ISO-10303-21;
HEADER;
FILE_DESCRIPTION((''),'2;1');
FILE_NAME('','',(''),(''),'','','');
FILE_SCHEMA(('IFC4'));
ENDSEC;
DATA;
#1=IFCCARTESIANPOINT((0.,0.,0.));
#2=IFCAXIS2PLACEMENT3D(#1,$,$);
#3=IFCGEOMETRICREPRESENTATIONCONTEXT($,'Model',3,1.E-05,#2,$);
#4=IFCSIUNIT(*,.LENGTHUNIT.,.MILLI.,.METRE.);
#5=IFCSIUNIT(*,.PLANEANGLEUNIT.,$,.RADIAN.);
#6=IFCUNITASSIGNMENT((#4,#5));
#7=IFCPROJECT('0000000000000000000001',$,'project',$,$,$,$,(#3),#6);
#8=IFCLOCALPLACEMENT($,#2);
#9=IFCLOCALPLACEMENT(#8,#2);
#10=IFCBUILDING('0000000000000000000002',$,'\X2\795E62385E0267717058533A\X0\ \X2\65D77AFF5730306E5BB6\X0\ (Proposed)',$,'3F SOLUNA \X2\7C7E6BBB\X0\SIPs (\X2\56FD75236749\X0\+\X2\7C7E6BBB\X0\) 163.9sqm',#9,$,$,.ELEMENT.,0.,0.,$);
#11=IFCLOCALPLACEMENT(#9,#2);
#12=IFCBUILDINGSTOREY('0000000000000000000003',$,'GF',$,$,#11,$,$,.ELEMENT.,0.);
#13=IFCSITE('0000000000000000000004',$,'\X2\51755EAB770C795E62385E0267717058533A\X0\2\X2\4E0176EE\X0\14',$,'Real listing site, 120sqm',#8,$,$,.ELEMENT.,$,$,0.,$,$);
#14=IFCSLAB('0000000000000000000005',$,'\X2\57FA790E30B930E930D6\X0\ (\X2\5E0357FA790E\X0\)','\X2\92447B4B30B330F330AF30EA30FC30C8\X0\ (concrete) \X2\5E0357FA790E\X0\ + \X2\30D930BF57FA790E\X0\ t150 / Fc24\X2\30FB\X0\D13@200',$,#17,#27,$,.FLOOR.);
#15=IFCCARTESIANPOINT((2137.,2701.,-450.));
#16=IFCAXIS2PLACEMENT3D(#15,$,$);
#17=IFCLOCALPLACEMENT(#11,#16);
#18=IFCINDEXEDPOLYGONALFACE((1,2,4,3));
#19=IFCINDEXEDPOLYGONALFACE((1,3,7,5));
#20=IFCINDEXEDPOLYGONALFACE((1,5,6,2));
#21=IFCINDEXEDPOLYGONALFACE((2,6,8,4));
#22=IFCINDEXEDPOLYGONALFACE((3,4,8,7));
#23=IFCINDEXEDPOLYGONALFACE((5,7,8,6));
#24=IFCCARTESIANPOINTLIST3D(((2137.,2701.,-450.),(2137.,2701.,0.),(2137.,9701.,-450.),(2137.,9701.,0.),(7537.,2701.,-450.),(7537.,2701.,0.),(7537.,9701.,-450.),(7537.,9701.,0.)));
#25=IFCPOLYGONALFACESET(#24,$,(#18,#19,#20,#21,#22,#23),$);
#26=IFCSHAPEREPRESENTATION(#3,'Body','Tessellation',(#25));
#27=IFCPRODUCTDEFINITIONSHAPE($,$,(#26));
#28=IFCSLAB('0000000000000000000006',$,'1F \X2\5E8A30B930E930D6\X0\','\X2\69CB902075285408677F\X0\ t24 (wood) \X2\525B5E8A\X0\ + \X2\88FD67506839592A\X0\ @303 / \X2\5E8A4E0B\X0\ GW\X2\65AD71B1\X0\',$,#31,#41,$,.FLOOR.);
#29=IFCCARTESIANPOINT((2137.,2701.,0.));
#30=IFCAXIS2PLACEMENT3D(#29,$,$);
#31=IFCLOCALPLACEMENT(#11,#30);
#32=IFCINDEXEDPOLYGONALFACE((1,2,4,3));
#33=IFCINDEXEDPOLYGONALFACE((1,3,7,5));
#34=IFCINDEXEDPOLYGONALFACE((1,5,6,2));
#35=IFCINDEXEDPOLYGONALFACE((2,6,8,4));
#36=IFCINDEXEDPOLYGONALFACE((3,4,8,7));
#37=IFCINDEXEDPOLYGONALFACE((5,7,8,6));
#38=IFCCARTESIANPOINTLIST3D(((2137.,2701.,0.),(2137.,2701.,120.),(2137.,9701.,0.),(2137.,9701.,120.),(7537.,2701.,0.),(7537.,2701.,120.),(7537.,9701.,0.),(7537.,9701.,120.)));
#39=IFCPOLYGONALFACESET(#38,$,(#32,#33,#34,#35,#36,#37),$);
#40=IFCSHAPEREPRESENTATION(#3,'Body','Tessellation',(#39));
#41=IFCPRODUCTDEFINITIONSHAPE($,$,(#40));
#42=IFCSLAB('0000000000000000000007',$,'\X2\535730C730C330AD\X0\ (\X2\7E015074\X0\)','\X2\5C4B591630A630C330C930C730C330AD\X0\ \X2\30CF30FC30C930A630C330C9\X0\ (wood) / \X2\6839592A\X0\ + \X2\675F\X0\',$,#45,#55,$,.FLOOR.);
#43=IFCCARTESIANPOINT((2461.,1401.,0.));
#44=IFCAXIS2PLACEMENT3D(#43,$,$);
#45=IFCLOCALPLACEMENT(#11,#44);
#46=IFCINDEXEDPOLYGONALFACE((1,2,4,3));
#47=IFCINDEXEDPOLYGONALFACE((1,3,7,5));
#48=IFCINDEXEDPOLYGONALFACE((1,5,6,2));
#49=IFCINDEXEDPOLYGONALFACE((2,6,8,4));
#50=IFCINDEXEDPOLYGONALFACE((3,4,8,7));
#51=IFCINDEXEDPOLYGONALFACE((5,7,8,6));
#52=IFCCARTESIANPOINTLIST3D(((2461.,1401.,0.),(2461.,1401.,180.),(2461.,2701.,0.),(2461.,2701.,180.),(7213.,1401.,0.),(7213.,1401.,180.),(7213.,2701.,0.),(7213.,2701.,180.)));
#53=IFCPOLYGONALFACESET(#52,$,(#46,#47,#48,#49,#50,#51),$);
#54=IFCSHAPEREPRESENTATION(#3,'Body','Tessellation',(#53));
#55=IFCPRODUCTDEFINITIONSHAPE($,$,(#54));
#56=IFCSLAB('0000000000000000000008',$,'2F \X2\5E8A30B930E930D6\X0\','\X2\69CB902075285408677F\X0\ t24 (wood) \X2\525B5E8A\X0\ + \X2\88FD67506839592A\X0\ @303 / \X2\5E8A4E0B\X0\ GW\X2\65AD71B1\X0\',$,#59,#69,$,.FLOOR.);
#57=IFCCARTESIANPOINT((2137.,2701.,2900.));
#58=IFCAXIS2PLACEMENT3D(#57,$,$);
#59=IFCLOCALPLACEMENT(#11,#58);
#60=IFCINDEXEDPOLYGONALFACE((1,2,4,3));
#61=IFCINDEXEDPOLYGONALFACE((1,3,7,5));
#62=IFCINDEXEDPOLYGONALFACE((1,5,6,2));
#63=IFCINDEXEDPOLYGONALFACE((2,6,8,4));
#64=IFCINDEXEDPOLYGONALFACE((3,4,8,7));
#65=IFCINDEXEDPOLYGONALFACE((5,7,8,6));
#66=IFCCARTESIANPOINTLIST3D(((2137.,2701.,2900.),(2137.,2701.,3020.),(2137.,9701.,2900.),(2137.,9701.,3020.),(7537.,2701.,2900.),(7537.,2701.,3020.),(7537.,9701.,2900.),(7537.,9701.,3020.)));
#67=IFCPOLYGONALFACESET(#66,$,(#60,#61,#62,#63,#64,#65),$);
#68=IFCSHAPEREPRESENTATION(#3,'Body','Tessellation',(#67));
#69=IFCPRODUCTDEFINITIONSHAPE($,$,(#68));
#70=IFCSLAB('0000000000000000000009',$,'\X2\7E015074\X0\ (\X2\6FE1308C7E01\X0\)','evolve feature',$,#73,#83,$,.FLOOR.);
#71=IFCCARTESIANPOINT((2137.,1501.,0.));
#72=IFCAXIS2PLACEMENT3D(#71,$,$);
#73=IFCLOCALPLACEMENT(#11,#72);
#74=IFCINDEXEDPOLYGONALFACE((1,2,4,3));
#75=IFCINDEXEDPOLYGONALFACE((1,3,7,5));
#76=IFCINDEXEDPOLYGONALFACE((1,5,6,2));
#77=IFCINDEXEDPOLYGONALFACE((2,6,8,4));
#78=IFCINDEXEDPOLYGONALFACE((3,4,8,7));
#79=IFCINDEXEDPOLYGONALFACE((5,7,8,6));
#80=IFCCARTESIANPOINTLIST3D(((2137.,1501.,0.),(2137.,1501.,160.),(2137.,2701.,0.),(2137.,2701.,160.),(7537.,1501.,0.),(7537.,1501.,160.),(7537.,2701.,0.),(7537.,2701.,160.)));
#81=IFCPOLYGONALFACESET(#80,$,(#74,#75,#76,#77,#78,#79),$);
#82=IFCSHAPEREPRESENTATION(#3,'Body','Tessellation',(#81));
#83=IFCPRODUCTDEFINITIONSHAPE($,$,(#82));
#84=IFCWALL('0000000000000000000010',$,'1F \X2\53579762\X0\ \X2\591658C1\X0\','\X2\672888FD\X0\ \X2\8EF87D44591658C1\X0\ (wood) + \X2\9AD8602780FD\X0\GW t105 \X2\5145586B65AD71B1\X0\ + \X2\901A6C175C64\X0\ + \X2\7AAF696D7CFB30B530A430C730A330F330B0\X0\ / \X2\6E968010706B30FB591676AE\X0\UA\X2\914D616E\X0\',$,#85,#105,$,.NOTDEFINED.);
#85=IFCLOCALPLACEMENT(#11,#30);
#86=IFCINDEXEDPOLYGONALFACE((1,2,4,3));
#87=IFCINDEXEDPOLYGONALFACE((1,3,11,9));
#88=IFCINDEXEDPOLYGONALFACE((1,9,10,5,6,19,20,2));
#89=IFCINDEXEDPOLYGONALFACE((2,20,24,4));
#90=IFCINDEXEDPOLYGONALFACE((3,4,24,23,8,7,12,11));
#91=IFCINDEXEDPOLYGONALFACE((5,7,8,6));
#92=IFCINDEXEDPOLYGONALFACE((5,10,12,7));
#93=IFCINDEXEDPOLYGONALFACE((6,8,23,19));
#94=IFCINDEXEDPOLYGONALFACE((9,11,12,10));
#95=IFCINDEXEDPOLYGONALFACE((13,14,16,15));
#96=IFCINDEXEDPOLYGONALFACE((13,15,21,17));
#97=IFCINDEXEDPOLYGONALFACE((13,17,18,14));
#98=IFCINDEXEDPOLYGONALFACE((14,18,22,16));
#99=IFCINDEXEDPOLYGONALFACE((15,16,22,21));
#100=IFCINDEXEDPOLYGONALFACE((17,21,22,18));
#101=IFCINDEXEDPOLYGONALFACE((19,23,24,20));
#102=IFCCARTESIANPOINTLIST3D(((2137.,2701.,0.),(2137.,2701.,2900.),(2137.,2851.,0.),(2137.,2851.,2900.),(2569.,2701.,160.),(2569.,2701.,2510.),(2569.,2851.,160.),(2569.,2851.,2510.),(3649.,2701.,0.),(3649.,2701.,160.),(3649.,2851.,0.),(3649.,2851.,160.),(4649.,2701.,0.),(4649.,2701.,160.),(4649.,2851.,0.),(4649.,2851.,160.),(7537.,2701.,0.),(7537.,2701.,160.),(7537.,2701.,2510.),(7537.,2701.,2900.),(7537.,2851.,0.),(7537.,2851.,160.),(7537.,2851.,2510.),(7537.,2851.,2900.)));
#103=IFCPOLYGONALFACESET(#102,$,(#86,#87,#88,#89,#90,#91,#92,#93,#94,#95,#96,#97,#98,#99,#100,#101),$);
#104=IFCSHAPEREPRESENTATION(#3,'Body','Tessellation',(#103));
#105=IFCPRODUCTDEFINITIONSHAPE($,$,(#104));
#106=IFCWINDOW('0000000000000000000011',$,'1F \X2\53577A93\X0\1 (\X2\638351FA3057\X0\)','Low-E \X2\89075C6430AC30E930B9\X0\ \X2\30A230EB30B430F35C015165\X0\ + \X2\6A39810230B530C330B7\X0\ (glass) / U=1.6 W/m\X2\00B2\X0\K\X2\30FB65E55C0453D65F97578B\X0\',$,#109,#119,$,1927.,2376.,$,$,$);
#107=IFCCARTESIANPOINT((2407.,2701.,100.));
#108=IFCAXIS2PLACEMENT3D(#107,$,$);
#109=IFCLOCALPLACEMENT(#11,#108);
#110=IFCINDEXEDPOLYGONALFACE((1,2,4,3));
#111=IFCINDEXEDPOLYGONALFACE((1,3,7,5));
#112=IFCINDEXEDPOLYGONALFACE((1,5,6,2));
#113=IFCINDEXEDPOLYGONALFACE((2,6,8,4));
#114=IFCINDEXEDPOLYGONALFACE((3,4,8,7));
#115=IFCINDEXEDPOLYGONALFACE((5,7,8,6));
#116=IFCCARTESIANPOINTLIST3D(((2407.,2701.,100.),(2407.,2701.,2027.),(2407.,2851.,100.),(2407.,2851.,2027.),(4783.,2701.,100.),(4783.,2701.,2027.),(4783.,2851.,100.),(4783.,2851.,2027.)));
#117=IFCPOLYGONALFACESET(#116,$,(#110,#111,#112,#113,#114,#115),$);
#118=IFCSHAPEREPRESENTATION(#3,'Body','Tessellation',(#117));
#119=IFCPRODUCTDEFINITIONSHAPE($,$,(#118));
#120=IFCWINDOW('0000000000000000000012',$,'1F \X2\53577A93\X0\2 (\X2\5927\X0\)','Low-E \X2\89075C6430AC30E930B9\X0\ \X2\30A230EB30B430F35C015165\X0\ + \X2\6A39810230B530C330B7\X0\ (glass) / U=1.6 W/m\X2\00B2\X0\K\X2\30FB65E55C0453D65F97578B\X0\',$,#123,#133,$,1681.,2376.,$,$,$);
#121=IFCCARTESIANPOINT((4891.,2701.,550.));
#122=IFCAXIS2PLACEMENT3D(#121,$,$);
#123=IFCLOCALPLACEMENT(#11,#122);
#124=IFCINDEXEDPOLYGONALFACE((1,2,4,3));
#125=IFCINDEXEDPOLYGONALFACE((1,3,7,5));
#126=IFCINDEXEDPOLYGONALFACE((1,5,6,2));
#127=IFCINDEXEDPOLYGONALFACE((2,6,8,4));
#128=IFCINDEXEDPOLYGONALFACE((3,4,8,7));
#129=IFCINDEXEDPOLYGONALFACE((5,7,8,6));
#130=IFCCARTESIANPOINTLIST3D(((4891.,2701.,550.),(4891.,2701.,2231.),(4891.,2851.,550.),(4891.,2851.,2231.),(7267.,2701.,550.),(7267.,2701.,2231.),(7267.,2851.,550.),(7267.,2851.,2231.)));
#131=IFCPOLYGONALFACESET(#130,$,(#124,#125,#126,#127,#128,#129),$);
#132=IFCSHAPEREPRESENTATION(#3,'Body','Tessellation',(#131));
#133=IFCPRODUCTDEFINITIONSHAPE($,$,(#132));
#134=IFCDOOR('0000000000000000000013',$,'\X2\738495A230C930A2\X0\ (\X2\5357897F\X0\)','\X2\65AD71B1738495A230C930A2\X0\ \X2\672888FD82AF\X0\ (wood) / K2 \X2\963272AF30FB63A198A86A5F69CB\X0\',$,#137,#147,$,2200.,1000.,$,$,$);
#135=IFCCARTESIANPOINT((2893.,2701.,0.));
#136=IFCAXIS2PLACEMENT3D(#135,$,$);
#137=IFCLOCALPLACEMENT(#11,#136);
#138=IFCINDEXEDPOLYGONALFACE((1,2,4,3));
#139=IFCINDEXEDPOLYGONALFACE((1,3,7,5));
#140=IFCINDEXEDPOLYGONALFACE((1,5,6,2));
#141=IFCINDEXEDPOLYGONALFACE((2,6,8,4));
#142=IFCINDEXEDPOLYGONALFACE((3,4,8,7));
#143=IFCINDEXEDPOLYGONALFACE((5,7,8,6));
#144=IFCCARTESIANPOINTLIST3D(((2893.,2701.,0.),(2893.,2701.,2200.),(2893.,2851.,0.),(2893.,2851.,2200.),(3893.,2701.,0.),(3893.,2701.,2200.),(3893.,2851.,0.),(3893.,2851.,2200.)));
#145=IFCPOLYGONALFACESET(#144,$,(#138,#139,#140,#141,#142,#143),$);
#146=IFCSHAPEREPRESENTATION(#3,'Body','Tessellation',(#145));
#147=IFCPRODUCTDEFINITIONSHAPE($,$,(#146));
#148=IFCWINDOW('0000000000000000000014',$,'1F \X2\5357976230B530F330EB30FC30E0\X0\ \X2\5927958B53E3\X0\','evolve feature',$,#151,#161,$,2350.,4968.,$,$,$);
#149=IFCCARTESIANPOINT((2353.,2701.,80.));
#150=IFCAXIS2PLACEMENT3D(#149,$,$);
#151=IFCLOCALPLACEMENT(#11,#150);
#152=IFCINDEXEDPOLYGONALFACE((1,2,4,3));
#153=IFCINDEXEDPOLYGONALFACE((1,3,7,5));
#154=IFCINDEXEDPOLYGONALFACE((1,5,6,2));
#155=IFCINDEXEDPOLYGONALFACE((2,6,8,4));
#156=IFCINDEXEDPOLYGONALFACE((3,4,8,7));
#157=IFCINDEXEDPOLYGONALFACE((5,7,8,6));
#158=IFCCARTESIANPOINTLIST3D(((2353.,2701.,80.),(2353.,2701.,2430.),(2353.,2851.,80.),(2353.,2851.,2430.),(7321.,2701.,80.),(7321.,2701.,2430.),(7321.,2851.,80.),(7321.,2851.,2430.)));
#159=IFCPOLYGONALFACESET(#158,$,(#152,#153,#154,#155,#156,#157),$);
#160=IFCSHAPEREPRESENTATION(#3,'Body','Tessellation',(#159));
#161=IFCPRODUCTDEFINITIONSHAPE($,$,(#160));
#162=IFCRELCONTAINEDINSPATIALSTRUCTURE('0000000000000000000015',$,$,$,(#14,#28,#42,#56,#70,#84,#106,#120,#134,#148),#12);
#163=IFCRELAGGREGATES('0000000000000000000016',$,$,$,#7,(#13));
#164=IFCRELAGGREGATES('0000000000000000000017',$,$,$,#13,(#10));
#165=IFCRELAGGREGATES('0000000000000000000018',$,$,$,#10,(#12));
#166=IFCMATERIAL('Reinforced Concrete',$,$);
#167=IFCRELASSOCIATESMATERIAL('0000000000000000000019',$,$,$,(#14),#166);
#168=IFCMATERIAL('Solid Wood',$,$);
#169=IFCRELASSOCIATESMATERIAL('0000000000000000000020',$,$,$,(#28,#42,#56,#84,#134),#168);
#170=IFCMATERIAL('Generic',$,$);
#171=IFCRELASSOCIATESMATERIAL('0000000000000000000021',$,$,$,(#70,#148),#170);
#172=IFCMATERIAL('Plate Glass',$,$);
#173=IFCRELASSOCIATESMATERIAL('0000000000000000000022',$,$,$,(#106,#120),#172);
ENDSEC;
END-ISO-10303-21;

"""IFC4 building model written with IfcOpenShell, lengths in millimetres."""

from ifc_helpers import new_model, si_unit, frame, frame_2d, origin, place, context, project, spatial, rectangle, extrude, material, element, fill, save


model = new_model("IFC4")

# Units and contexts
model_context = context("Model", 3, precision=1e-05, world=origin())
ifc_project = project(units=[si_unit("LENGTHUNIT", "METRE", prefix="MILLI"), si_unit("PLANEANGLEUNIT", "RADIAN")], contexts=[model_context])

# Site, building, storey
site_placement = place(None, origin())
site = spatial("IfcSite", under=ifc_project, at=site_placement, Name="兵庫県神戸市東灘区2丁目14", ObjectType="Real listing site, 120sqm", CompositionType="ELEMENT", RefElevation=0.0)
building_placement = place(site_placement, origin())
building = spatial("IfcBuilding", under=site, at=building_placement, Name="神戸市東灘区 旗竿地の家 (Proposed)", ObjectType="3F SOLUNA 籾殻SIPs (国産杉+籾殻) 163.9sqm", CompositionType="ELEMENT", ElevationOfRefHeight=0.0, ElevationOfTerrain=0.0)
storey_placement = place(building_placement, origin())
storey = spatial("IfcBuildingStorey", under=building, at=storey_placement, Name="GF", CompositionType="ELEMENT", Elevation=0.0)

# Slabs
ifc_material_1 = material(Name="Reinforced Concrete")
slab_1_placement = place(storey_placement, frame((2137.0, 2701.0, -450.0)))
element("IfcSlab", 1, at=slab_1_placement, inside=storey, material=ifc_material_1, Name="基礎スラブ (布基礎)", Description="鉄筋コンクリート (concrete) 布基礎 + ベタ基礎 t150 / Fc24・D13@200", PredefinedType="FLOOR", context=model_context, shape_type="SweptSolid", body=[
    extrude(rectangle(XDim=5400.0, YDim=7000.0, at=frame_2d((2700.0, 3500.0))), frame((2137.0, 2701.0, -450.0)), (0.0, 0.0, 1.0), 450.0),
])
ifc_material_2 = material(Name="Solid Wood")
slab_2_placement = place(storey_placement, frame((2137.0, 2701.0, 0.0)))
element("IfcSlab", 2, at=slab_2_placement, inside=storey, material=ifc_material_2, Name="1F 床スラブ", Description="構造用合板 t24 (wood) 剛床 + 製材根太 @303 / 床下 GW断熱", PredefinedType="FLOOR", context=model_context, shape_type="SweptSolid", body=[
    extrude(rectangle(XDim=5400.0, YDim=7000.0, at=frame_2d((2700.0, 3500.0))), frame((2137.0, 2701.0, 0.0)), (0.0, 0.0, 1.0), 120.0),
])
slab_3_placement = place(storey_placement, frame((2461.0, 1401.0, 0.0)))
element("IfcSlab", 3, at=slab_3_placement, inside=storey, material=ifc_material_2, Name="南デッキ (縁側)", Description="屋外ウッドデッキ ハードウッド (wood) / 根太 + 束", PredefinedType="FLOOR", context=model_context, shape_type="SweptSolid", body=[
    extrude(rectangle(XDim=4752.0, YDim=1300.0, at=frame_2d((2376.0, 650.0))), frame((2461.0, 1401.0, 0.0)), (0.0, 0.0, 1.0), 180.0),
])
slab_4_placement = place(storey_placement, frame((2137.0, 2701.0, 2900.0)))
element("IfcSlab", 4, at=slab_4_placement, inside=storey, material=ifc_material_2, Name="2F 床スラブ", Description="構造用合板 t24 (wood) 剛床 + 製材根太 @303 / 床下 GW断熱", PredefinedType="FLOOR", context=model_context, shape_type="SweptSolid", body=[
    extrude(rectangle(XDim=5400.0, YDim=7000.0, at=frame_2d((2700.0, 3500.0))), frame((2137.0, 2701.0, 2900.0)), (0.0, 0.0, 1.0), 120.0),
])
ifc_material_3 = material(Name="Generic")
slab_5_placement = place(storey_placement, frame((2137.0, 1501.0, 0.0)))
element("IfcSlab", 5, at=slab_5_placement, inside=storey, material=ifc_material_3, Name="縁側 (濡れ縁)", Description="evolve feature", PredefinedType="FLOOR", context=model_context, shape_type="SweptSolid", body=[
    extrude(rectangle(XDim=5400.0, YDim=1200.0, at=frame_2d((2700.0, 600.0))), frame((2137.0, 1501.0, 0.0)), (0.0, 0.0, 1.0), 160.0),
])

# Wall, openings, windows, door
wall_1_placement = place(storey_placement, frame((2137.0, 2701.0, 0.0)))
wall_1 = element("IfcWall", 6, at=wall_1_placement, inside=storey, material=ifc_material_2, Name="1F 南面 外壁", Description="木製 軸組外壁 (wood) + 高性能GW t105 充填断熱 + 通気層 + 窯業系サイディング / 準耐火・外皮UA配慮", PredefinedType="NOTDEFINED", context=model_context, shape_type="SweptSolid", body=[
    extrude(rectangle(XDim=5400.0, YDim=150.0, at=frame_2d((2700.0, 75.0))), frame((2137.0, 2701.0, 0.0)), (0.0, 0.0, 1.0), 2900.0),
])
opening_1_placement = place(storey_placement, frame((2407.0, 2701.0, 100.0)))
opening_1 = element("IfcOpeningElement", 7, at=opening_1_placement, cuts=wall_1, PredefinedType="NOTDEFINED", context=model_context, shape_type="SweptSolid", body=[
    extrude(rectangle(XDim=2376.0, YDim=150.0, at=frame_2d((1188.0, 75.0))), frame((2407.0, 2701.0, 100.0)), (0.0, 0.0, 1.0), 1927.0),
])
opening_2_placement = place(storey_placement, frame((4891.0, 2701.0, 550.0)))
opening_2 = element("IfcOpeningElement", 8, at=opening_2_placement, cuts=wall_1, PredefinedType="NOTDEFINED", context=model_context, shape_type="SweptSolid", body=[
    extrude(rectangle(XDim=2376.0, YDim=150.0, at=frame_2d((1188.0, 75.0))), frame((4891.0, 2701.0, 550.0)), (0.0, 0.0, 1.0), 1681.0),
])
opening_3_placement = place(storey_placement, frame((2893.0, 2701.0, 0.0)))
opening_3 = element("IfcOpeningElement", 9, at=opening_3_placement, cuts=wall_1, PredefinedType="NOTDEFINED", context=model_context, shape_type="SweptSolid", body=[
    extrude(rectangle(XDim=1000.0, YDim=150.0, at=frame_2d((500.0, 75.0))), frame((2893.0, 2701.0, 0.0)), (0.0, 0.0, 1.0), 2200.0),
])
opening_4_placement = place(storey_placement, frame((2353.0, 2701.0, 80.0)))
opening_4 = element("IfcOpeningElement", 10, at=opening_4_placement, cuts=wall_1, PredefinedType="NOTDEFINED", context=model_context, shape_type="SweptSolid", body=[
    extrude(rectangle(XDim=4968.0, YDim=150.0, at=frame_2d((2484.0, 75.0))), frame((2353.0, 2701.0, 80.0)), (0.0, 0.0, 1.0), 2350.0),
])
ifc_material_4 = material(Name="Plate Glass")
window_1_placement = place(storey_placement, frame((2407.0, 2701.0, 100.0)))
window_1 = element("IfcWindow", 11, at=window_1_placement, inside=storey, material=ifc_material_4, Name="1F 南窓1 (掃出し)", Description="Low-E 複層ガラス アルゴン封入 + 樹脂サッシ (glass) / U=1.6 W/m²K・日射取得型", OverallHeight=1927.0, OverallWidth=2376.0, context=model_context, shape_type="SweptSolid", body=[
    extrude(rectangle(XDim=2376.0, YDim=150.0, at=frame_2d((1188.0, 75.0))), frame((2407.0, 2701.0, 100.0)), (0.0, 0.0, 1.0), 1927.0),
])
fill(opening_1, window_1)
window_2_placement = place(storey_placement, frame((4891.0, 2701.0, 550.0)))
window_2 = element("IfcWindow", 12, at=window_2_placement, inside=storey, material=ifc_material_4, Name="1F 南窓2 (大)", Description="Low-E 複層ガラス アルゴン封入 + 樹脂サッシ (glass) / U=1.6 W/m²K・日射取得型", OverallHeight=1681.0, OverallWidth=2376.0, context=model_context, shape_type="SweptSolid", body=[
    extrude(rectangle(XDim=2376.0, YDim=150.0, at=frame_2d((1188.0, 75.0))), frame((4891.0, 2701.0, 550.0)), (0.0, 0.0, 1.0), 1681.0),
])
fill(opening_2, window_2)
door_placement = place(storey_placement, frame((2893.0, 2701.0, 0.0)))
door = element("IfcDoor", 13, at=door_placement, inside=storey, material=ifc_material_2, Name="玄関ドア (南西)", Description="断熱玄関ドア 木製芯 (wood) / K2 防犯・採風機構", OverallHeight=2200.0, OverallWidth=1000.0, context=model_context, shape_type="SweptSolid", body=[
    extrude(rectangle(XDim=1000.0, YDim=150.0, at=frame_2d((500.0, 75.0))), frame((2893.0, 2701.0, 0.0)), (0.0, 0.0, 1.0), 2200.0),
])
fill(opening_3, door)
window_3_placement = place(storey_placement, frame((2353.0, 2701.0, 80.0)))
window_3 = element("IfcWindow", 14, at=window_3_placement, inside=storey, material=ifc_material_3, Name="1F 南面サンルーム 大開口", Description="evolve feature", OverallHeight=2350.0, OverallWidth=4968.0, context=model_context, shape_type="SweptSolid", body=[
    extrude(rectangle(XDim=4968.0, YDim=150.0, at=frame_2d((2484.0, 75.0))), frame((2353.0, 2701.0, 80.0)), (0.0, 0.0, 1.0), 2350.0),
])
fill(opening_4, window_3)

save(model, "model.ifc")
